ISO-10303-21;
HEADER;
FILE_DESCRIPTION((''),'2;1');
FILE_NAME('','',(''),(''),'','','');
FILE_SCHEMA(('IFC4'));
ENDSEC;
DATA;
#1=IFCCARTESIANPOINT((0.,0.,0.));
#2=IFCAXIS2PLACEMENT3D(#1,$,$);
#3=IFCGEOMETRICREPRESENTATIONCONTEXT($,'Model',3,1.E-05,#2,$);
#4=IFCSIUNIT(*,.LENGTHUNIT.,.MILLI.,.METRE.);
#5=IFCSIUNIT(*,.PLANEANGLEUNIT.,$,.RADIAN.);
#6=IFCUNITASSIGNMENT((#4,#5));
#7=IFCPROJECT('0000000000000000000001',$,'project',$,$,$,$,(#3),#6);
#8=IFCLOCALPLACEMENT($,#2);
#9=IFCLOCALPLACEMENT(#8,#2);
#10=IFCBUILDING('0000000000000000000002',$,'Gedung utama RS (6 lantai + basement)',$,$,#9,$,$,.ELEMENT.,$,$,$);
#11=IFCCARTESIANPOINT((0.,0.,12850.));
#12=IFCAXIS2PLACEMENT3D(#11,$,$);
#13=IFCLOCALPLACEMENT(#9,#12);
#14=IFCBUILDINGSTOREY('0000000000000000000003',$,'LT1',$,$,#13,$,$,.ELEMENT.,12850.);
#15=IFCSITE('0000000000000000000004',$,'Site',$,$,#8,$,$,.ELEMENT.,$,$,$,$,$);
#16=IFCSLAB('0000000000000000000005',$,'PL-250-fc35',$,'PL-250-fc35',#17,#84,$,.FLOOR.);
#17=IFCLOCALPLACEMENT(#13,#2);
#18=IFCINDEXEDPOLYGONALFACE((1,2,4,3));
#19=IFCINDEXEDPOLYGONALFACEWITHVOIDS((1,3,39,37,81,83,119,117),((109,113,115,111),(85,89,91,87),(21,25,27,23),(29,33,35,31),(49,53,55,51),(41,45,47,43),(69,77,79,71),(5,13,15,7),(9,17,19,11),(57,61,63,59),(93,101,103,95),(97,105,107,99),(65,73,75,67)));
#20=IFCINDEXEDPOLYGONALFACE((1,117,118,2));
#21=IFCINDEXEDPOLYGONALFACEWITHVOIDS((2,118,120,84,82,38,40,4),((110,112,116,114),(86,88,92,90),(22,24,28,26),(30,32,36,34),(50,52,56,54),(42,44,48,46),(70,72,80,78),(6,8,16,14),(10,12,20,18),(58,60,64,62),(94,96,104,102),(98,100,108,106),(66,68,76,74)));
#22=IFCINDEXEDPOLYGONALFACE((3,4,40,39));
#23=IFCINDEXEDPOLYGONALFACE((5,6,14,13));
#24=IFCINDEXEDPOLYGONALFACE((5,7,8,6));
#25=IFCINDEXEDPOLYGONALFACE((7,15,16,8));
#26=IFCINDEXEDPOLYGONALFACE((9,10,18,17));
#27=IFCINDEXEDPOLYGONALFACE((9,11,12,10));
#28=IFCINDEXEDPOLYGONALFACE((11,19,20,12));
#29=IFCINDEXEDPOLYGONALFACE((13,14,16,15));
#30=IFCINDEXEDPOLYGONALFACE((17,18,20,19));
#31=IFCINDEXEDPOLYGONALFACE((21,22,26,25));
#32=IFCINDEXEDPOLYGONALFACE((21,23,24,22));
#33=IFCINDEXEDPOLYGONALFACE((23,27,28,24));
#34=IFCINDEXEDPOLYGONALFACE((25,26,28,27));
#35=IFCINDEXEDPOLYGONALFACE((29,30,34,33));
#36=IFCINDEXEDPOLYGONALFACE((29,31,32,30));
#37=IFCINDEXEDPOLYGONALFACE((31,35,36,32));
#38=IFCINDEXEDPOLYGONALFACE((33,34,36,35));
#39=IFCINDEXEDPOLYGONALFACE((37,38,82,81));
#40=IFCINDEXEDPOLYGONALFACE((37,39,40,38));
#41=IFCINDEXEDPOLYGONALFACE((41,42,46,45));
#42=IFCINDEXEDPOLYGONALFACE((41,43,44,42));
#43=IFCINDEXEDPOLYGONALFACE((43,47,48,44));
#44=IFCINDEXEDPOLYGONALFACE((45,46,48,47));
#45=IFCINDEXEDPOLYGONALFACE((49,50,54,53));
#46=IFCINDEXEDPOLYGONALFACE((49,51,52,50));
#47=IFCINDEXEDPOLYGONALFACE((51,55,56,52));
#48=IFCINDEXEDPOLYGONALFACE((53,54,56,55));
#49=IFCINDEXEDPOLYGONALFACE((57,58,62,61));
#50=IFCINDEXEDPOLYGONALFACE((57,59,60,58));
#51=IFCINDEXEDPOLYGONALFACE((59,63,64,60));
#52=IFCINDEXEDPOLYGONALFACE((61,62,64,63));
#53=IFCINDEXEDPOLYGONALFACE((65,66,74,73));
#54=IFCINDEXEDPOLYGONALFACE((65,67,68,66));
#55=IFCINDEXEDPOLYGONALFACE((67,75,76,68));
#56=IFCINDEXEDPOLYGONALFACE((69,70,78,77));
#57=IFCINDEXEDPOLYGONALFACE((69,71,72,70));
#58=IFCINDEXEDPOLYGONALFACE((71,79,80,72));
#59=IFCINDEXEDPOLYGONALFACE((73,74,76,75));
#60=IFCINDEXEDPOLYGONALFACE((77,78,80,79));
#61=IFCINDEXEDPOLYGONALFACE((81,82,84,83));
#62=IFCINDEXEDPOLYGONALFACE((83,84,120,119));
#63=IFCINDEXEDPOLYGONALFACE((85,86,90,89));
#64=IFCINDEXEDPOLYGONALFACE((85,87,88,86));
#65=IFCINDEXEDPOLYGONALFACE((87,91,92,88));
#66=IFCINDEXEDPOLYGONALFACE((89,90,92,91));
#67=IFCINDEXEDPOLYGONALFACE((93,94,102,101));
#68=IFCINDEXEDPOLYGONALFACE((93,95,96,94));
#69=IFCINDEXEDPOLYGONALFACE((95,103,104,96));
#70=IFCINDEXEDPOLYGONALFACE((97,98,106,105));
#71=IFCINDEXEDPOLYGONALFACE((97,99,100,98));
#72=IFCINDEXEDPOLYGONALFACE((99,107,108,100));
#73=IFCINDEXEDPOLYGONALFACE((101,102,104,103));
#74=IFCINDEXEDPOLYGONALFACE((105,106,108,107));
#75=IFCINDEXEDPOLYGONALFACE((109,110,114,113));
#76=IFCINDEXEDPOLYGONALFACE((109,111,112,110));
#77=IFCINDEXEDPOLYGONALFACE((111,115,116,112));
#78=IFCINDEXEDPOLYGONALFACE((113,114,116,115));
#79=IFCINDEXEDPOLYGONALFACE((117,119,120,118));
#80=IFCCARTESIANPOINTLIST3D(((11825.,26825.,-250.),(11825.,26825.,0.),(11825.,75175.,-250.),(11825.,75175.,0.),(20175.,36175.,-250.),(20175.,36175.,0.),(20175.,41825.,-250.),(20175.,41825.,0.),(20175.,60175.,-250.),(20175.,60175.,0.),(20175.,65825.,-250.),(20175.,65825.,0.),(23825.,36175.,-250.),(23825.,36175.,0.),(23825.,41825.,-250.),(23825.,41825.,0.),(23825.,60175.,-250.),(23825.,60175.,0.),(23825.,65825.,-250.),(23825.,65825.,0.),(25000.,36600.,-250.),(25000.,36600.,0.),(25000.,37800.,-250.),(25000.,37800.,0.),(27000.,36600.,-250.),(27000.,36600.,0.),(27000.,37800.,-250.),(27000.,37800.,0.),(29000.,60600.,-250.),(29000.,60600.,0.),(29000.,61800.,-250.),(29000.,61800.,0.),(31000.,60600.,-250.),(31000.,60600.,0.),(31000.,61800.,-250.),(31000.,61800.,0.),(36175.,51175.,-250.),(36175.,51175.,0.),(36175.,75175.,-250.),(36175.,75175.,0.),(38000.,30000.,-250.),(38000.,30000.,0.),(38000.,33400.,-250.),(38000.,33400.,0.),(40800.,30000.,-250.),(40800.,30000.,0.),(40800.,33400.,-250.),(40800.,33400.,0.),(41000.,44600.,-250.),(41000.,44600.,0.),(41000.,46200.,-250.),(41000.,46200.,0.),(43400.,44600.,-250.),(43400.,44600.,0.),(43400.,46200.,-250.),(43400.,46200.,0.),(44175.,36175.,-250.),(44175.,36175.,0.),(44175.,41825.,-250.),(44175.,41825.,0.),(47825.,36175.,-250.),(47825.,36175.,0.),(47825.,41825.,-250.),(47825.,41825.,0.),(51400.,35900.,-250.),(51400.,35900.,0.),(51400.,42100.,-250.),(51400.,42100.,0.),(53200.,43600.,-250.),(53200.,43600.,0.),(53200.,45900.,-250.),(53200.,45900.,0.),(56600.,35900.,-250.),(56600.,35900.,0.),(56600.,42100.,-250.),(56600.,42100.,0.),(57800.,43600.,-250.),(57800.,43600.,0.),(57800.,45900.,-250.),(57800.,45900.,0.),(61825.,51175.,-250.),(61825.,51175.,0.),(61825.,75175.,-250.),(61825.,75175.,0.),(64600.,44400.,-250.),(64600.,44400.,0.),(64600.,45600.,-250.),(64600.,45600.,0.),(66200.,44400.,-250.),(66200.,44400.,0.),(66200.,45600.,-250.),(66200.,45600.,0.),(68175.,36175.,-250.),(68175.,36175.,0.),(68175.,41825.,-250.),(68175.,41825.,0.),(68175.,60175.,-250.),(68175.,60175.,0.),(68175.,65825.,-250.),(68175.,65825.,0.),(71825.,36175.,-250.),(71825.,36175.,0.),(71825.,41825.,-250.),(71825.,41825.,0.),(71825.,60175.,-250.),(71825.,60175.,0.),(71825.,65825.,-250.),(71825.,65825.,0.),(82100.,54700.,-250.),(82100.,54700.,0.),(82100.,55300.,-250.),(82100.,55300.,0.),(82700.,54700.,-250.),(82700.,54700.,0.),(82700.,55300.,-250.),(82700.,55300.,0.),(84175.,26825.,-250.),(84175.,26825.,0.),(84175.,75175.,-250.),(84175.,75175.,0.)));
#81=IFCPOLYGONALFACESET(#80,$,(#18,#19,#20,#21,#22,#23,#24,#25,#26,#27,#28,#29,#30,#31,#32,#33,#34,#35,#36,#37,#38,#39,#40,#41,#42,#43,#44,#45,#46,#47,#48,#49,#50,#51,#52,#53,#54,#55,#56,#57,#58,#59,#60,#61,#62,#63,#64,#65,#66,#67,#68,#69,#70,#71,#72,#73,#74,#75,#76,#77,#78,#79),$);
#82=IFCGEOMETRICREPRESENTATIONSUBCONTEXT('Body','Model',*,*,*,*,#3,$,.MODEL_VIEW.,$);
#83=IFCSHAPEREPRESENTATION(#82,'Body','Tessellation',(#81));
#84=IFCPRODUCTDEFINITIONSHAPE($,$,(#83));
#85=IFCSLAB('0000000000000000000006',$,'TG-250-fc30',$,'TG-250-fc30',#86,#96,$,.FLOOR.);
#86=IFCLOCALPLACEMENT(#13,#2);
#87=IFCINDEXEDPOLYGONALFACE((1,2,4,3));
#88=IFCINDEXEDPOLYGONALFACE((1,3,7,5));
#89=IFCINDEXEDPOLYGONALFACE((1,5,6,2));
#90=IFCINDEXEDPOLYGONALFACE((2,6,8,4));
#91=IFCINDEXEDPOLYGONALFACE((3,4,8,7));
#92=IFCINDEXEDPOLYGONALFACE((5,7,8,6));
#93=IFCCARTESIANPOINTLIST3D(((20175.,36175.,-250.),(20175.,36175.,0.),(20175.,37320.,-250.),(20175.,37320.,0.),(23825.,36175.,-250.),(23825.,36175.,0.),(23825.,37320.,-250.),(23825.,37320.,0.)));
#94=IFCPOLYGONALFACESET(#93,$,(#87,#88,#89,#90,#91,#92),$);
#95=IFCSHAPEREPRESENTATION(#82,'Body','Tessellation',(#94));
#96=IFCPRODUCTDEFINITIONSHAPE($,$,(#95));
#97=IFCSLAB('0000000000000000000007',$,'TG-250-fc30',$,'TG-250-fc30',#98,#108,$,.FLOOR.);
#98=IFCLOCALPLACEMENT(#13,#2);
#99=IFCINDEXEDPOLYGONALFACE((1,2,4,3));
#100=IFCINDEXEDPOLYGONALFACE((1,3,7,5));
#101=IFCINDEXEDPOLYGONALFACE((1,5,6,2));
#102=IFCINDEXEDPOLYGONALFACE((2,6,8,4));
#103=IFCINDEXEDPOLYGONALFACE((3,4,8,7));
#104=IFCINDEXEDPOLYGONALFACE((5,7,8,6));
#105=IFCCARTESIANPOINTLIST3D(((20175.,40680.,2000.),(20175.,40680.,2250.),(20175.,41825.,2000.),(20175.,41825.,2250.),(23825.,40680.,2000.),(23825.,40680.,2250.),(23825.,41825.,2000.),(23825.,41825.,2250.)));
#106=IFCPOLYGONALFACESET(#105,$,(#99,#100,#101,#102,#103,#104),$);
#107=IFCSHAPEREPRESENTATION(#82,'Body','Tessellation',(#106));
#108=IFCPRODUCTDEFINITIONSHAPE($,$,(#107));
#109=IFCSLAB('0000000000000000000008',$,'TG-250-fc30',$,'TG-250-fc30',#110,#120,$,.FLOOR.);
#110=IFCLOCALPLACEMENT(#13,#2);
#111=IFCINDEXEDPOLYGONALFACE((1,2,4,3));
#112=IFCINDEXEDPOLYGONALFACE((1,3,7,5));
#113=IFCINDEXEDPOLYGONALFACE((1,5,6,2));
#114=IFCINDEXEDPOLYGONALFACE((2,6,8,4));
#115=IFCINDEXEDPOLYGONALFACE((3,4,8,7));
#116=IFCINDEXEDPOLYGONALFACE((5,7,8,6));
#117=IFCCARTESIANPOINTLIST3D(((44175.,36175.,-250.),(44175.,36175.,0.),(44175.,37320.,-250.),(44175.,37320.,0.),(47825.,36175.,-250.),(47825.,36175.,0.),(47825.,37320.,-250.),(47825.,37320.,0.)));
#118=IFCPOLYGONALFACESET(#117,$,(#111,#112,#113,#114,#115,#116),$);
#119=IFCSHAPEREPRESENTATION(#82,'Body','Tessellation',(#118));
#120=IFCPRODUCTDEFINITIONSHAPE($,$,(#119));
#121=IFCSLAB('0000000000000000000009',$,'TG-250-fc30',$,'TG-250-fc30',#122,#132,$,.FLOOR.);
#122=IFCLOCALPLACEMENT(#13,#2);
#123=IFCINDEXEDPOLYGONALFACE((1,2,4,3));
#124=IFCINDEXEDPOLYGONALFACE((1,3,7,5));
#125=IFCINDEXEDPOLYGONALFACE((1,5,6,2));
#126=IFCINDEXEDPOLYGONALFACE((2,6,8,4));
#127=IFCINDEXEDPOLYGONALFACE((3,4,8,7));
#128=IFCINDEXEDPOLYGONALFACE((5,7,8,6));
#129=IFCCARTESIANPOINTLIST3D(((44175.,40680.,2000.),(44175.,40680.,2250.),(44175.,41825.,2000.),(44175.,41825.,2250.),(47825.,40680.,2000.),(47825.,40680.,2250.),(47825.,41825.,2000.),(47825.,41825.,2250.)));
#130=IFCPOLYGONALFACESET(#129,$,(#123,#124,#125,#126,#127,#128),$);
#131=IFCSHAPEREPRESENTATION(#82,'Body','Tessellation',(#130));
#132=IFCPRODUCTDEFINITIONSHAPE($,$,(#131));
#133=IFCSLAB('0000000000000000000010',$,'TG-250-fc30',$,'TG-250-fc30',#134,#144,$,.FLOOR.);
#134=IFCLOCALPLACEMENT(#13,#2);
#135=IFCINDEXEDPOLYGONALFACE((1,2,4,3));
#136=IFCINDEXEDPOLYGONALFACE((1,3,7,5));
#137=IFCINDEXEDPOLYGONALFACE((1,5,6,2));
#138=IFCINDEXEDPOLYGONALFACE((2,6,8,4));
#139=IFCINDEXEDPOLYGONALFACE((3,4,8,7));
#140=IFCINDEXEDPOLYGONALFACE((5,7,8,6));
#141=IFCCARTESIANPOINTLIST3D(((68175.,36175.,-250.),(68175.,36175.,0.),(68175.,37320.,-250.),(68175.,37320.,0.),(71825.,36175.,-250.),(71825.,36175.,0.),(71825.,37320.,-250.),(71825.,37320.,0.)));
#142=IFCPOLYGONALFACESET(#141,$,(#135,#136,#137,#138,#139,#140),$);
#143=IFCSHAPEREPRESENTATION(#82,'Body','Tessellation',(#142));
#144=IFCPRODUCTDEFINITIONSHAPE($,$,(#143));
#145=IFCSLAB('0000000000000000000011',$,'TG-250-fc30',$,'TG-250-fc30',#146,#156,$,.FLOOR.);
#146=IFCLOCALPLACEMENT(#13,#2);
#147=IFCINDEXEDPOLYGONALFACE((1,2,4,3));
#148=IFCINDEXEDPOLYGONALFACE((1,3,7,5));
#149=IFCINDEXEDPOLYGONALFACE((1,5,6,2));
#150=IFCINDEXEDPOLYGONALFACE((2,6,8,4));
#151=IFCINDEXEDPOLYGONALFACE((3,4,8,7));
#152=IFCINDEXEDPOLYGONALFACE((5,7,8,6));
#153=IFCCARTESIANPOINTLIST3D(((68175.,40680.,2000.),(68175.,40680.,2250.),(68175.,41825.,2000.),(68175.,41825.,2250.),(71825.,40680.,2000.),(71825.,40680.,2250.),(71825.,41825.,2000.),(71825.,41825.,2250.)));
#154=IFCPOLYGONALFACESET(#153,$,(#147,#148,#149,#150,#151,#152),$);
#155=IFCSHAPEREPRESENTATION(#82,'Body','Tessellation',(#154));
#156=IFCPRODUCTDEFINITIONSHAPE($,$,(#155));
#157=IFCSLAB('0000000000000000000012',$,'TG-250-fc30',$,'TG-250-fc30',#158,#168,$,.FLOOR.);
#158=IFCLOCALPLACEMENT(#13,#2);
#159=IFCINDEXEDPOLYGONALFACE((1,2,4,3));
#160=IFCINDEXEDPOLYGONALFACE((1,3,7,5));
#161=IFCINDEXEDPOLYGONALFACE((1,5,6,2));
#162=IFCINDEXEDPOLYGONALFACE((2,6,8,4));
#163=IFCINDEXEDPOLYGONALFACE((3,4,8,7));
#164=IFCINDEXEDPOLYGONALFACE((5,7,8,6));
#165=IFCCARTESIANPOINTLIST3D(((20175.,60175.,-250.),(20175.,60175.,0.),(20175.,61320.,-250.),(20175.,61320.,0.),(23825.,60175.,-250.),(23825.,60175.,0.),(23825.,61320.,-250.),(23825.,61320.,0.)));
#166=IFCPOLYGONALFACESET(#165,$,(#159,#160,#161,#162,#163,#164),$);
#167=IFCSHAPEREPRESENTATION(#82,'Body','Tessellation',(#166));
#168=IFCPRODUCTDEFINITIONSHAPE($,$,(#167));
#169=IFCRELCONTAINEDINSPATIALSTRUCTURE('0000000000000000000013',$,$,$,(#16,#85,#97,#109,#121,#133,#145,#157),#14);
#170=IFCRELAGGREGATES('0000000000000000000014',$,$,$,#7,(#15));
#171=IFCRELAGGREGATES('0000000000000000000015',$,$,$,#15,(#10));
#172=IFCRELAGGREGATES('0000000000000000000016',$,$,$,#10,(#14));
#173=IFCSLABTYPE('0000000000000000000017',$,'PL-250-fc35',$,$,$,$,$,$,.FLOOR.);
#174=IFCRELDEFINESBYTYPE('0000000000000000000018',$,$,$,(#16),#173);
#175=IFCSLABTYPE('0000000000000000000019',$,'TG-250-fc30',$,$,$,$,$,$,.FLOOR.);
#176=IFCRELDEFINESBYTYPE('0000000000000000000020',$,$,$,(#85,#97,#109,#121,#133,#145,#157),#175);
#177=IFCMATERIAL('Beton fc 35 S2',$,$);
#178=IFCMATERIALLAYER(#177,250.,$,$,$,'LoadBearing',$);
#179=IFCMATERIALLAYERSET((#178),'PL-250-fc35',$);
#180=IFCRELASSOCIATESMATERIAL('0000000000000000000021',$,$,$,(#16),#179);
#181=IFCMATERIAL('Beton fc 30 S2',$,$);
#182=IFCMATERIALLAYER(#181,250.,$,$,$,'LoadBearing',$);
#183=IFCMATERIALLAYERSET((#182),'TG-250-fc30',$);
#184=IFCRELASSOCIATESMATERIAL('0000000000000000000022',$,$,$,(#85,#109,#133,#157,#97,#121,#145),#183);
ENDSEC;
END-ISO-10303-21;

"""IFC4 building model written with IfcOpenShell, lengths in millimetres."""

from ifc_helpers import new_model, si_unit, frame, origin, place, context, subcontext, project, spatial, polyline, outline, extrude, material, layer, layer_set, layer_usage, type_object, element, save


model = new_model("IFC4")

# Units and contexts
model_context = context("Model", 3, precision=1e-05, world=origin())
body_context = subcontext(model_context, "Body", "Model", "MODEL_VIEW")
ifc_project = project(units=[si_unit("LENGTHUNIT", "METRE", prefix="MILLI"), si_unit("PLANEANGLEUNIT", "RADIAN")], contexts=[model_context])

# Site, building, storey
site_placement = place(None, origin())
site = spatial("IfcSite", under=ifc_project, at=site_placement, Name="Site", CompositionType="ELEMENT")
building_placement = place(site_placement, origin())
building = spatial("IfcBuilding", under=site, at=building_placement, Name="Gedung utama RS (6 lantai + basement)", CompositionType="ELEMENT")
storey_placement = place(building_placement, frame((0.0, 0.0, 12850.0)))
storey = spatial("IfcBuildingStorey", under=building, at=storey_placement, Name="LT1", CompositionType="ELEMENT", Elevation=12850.0)

# Shared definitions
ifc_material_1 = material(Name="Beton fc 35 S2")

# Slabs
ifc_layer_1 = layer(ifc_material_1, 250.0, Category="LoadBearing")
ifc_layer_set_1 = layer_set([ifc_layer_1], Name="PL-250-fc35")
ifc_layer_usage_1 = layer_usage(ifc_layer_set_1, "AXIS3", "NEGATIVE", 0.0)
slab_type_1 = type_object("IfcSlabType", Name="PL-250-fc35", PredefinedType="FLOOR")
slab_1_placement = place(storey_placement, origin())
element("IfcSlab", 1, at=slab_1_placement, inside=storey, type_object=slab_type_1, material=ifc_layer_usage_1, Name="PL-250-fc35", ObjectType="PL-250-fc35", PredefinedType="FLOOR", context=body_context, shape_type="SweptSolid", body=[
    extrude(outline(polyline([(61825.0, 75175.0), (61825.0, 51175.0), (36175.0, 51175.0), (36175.0, 75175.0), (11825.0, 75175.0), (11825.0, 26825.0), (84175.0, 26825.0), (84175.0, 75175.0), (61825.0, 75175.0)]), holes=[polyline([(27000.0, 36600.0), (27000.0, 37800.0), (25000.0, 37800.0), (25000.0, 36600.0), (27000.0, 36600.0)]), polyline([(43400.0, 44600.0), (43400.0, 46200.0), (41000.0, 46200.0), (41000.0, 44600.0), (43400.0, 44600.0)]), polyline([(66200.0, 44400.0), (66200.0, 45600.0), (64600.0, 45600.0), (64600.0, 44400.0), (66200.0, 44400.0)]), polyline([(31000.0, 60600.0), (31000.0, 61800.0), (29000.0, 61800.0), (29000.0, 60600.0), (31000.0, 60600.0)]), polyline([(82700.0, 54700.0), (82700.0, 55300.0), (82100.0, 55300.0), (82100.0, 54700.0), (82700.0, 54700.0)]), polyline([(23825.0, 36175.0), (23825.0, 41825.0), (20175.0, 41825.0), (20175.0, 36175.0), (23825.0, 36175.0)]), polyline([(47825.0, 36175.0), (47825.0, 41825.0), (44175.0, 41825.0), (44175.0, 36175.0), (47825.0, 36175.0)]), polyline([(71825.0, 36175.0), (71825.0, 41825.0), (68175.0, 41825.0), (68175.0, 36175.0), (71825.0, 36175.0)]), polyline([(23825.0, 60175.0), (23825.0, 65825.0), (20175.0, 65825.0), (20175.0, 60175.0), (23825.0, 60175.0)]), polyline([(71825.0, 60175.0), (71825.0, 65825.0), (68175.0, 65825.0), (68175.0, 60175.0), (71825.0, 60175.0)]), polyline([(56600.0, 35900.0), (56600.0, 42100.0), (51400.0, 42100.0), (51400.0, 35900.0), (56600.0, 35900.0)]), polyline([(57800.0, 43600.0), (57800.0, 45900.0), (53200.0, 45900.0), (53200.0, 43600.0), (57800.0, 43600.0)]), polyline([(40800.0, 30000.0), (40800.0, 33400.0), (38000.0, 33400.0), (38000.0, 30000.0), (40800.0, 30000.0)])]), frame((0.0, 0.0, -250.0)), (0.0, 0.0, 1.0), 250.0),
])
ifc_material_2 = material(Name="Beton fc 30 S2")
ifc_layer_2 = layer(ifc_material_2, 250.0, Category="LoadBearing")
ifc_layer_set_2 = layer_set([ifc_layer_2], Name="TG-250-fc30")
ifc_layer_usage_2 = layer_usage(ifc_layer_set_2, "AXIS3", "NEGATIVE", 0.0)
slab_type_2 = type_object("IfcSlabType", Name="TG-250-fc30", PredefinedType="FLOOR")
slab_2_placement = place(storey_placement, origin())
element("IfcSlab", 2, at=slab_2_placement, inside=storey, type_object=slab_type_2, material=ifc_layer_usage_2, Name="TG-250-fc30", ObjectType="TG-250-fc30", PredefinedType="FLOOR", context=body_context, shape_type="SweptSolid", body=[
    extrude(outline(polyline([(23825.0, 36175.0), (23825.0, 37320.0), (20175.0, 37320.0), (20175.0, 36175.0), (23825.0, 36175.0)])), frame((0.0, 0.0, -250.0)), (0.0, 0.0, 1.0), 250.0),
])
ifc_layer_usage_3 = layer_usage(ifc_layer_set_2, "AXIS3", "NEGATIVE", 2250.0)
slab_3_placement = place(storey_placement, origin())
element("IfcSlab", 3, at=slab_3_placement, inside=storey, type_object=slab_type_2, material=ifc_layer_usage_3, Name="TG-250-fc30", ObjectType="TG-250-fc30", PredefinedType="FLOOR", context=body_context, shape_type="SweptSolid", body=[
    extrude(outline(polyline([(23825.0, 40680.0), (23825.0, 41825.0), (20175.0, 41825.0), (20175.0, 40680.0), (23825.0, 40680.0)])), frame((0.0, 0.0, 2000.0)), (0.0, 0.0, 1.0), 250.0),
])
slab_4_placement = place(storey_placement, origin())
element("IfcSlab", 4, at=slab_4_placement, inside=storey, type_object=slab_type_2, material=ifc_layer_usage_2, Name="TG-250-fc30", ObjectType="TG-250-fc30", PredefinedType="FLOOR", context=body_context, shape_type="SweptSolid", body=[
    extrude(outline(polyline([(47825.0, 36175.0), (47825.0, 37320.0), (44175.0, 37320.0), (44175.0, 36175.0), (47825.0, 36175.0)])), frame((0.0, 0.0, -250.0)), (0.0, 0.0, 1.0), 250.0),
])
slab_5_placement = place(storey_placement, origin())
element("IfcSlab", 5, at=slab_5_placement, inside=storey, type_object=slab_type_2, material=ifc_layer_usage_3, Name="TG-250-fc30", ObjectType="TG-250-fc30", PredefinedType="FLOOR", context=body_context, shape_type="SweptSolid", body=[
    extrude(outline(polyline([(47825.0, 40680.0), (47825.0, 41825.0), (44175.0, 41825.0), (44175.0, 40680.0), (47825.0, 40680.0)])), frame((0.0, 0.0, 2000.0)), (0.0, 0.0, 1.0), 250.0),
])
slab_6_placement = place(storey_placement, origin())
element("IfcSlab", 6, at=slab_6_placement, inside=storey, type_object=slab_type_2, material=ifc_layer_usage_2, Name="TG-250-fc30", ObjectType="TG-250-fc30", PredefinedType="FLOOR", context=body_context, shape_type="SweptSolid", body=[
    extrude(outline(polyline([(71825.0, 36175.0), (71825.0, 37320.0), (68175.0, 37320.0), (68175.0, 36175.0), (71825.0, 36175.0)])), frame((0.0, 0.0, -250.0)), (0.0, 0.0, 1.0), 250.0),
])
slab_7_placement = place(storey_placement, origin())
element("IfcSlab", 7, at=slab_7_placement, inside=storey, type_object=slab_type_2, material=ifc_layer_usage_3, Name="TG-250-fc30", ObjectType="TG-250-fc30", PredefinedType="FLOOR", context=body_context, shape_type="SweptSolid", body=[
    extrude(outline(polyline([(71825.0, 40680.0), (71825.0, 41825.0), (68175.0, 41825.0), (68175.0, 40680.0), (71825.0, 40680.0)])), frame((0.0, 0.0, 2000.0)), (0.0, 0.0, 1.0), 250.0),
])
slab_8_placement = place(storey_placement, origin())
element("IfcSlab", 8, at=slab_8_placement, inside=storey, type_object=slab_type_2, material=ifc_layer_usage_2, Name="TG-250-fc30", ObjectType="TG-250-fc30", PredefinedType="FLOOR", context=body_context, shape_type="SweptSolid", body=[
    extrude(outline(polyline([(23825.0, 60175.0), (23825.0, 61320.0), (20175.0, 61320.0), (20175.0, 60175.0), (23825.0, 60175.0)])), frame((0.0, 0.0, -250.0)), (0.0, 0.0, 1.0), 250.0),
])

save(model, "model.ifc")
